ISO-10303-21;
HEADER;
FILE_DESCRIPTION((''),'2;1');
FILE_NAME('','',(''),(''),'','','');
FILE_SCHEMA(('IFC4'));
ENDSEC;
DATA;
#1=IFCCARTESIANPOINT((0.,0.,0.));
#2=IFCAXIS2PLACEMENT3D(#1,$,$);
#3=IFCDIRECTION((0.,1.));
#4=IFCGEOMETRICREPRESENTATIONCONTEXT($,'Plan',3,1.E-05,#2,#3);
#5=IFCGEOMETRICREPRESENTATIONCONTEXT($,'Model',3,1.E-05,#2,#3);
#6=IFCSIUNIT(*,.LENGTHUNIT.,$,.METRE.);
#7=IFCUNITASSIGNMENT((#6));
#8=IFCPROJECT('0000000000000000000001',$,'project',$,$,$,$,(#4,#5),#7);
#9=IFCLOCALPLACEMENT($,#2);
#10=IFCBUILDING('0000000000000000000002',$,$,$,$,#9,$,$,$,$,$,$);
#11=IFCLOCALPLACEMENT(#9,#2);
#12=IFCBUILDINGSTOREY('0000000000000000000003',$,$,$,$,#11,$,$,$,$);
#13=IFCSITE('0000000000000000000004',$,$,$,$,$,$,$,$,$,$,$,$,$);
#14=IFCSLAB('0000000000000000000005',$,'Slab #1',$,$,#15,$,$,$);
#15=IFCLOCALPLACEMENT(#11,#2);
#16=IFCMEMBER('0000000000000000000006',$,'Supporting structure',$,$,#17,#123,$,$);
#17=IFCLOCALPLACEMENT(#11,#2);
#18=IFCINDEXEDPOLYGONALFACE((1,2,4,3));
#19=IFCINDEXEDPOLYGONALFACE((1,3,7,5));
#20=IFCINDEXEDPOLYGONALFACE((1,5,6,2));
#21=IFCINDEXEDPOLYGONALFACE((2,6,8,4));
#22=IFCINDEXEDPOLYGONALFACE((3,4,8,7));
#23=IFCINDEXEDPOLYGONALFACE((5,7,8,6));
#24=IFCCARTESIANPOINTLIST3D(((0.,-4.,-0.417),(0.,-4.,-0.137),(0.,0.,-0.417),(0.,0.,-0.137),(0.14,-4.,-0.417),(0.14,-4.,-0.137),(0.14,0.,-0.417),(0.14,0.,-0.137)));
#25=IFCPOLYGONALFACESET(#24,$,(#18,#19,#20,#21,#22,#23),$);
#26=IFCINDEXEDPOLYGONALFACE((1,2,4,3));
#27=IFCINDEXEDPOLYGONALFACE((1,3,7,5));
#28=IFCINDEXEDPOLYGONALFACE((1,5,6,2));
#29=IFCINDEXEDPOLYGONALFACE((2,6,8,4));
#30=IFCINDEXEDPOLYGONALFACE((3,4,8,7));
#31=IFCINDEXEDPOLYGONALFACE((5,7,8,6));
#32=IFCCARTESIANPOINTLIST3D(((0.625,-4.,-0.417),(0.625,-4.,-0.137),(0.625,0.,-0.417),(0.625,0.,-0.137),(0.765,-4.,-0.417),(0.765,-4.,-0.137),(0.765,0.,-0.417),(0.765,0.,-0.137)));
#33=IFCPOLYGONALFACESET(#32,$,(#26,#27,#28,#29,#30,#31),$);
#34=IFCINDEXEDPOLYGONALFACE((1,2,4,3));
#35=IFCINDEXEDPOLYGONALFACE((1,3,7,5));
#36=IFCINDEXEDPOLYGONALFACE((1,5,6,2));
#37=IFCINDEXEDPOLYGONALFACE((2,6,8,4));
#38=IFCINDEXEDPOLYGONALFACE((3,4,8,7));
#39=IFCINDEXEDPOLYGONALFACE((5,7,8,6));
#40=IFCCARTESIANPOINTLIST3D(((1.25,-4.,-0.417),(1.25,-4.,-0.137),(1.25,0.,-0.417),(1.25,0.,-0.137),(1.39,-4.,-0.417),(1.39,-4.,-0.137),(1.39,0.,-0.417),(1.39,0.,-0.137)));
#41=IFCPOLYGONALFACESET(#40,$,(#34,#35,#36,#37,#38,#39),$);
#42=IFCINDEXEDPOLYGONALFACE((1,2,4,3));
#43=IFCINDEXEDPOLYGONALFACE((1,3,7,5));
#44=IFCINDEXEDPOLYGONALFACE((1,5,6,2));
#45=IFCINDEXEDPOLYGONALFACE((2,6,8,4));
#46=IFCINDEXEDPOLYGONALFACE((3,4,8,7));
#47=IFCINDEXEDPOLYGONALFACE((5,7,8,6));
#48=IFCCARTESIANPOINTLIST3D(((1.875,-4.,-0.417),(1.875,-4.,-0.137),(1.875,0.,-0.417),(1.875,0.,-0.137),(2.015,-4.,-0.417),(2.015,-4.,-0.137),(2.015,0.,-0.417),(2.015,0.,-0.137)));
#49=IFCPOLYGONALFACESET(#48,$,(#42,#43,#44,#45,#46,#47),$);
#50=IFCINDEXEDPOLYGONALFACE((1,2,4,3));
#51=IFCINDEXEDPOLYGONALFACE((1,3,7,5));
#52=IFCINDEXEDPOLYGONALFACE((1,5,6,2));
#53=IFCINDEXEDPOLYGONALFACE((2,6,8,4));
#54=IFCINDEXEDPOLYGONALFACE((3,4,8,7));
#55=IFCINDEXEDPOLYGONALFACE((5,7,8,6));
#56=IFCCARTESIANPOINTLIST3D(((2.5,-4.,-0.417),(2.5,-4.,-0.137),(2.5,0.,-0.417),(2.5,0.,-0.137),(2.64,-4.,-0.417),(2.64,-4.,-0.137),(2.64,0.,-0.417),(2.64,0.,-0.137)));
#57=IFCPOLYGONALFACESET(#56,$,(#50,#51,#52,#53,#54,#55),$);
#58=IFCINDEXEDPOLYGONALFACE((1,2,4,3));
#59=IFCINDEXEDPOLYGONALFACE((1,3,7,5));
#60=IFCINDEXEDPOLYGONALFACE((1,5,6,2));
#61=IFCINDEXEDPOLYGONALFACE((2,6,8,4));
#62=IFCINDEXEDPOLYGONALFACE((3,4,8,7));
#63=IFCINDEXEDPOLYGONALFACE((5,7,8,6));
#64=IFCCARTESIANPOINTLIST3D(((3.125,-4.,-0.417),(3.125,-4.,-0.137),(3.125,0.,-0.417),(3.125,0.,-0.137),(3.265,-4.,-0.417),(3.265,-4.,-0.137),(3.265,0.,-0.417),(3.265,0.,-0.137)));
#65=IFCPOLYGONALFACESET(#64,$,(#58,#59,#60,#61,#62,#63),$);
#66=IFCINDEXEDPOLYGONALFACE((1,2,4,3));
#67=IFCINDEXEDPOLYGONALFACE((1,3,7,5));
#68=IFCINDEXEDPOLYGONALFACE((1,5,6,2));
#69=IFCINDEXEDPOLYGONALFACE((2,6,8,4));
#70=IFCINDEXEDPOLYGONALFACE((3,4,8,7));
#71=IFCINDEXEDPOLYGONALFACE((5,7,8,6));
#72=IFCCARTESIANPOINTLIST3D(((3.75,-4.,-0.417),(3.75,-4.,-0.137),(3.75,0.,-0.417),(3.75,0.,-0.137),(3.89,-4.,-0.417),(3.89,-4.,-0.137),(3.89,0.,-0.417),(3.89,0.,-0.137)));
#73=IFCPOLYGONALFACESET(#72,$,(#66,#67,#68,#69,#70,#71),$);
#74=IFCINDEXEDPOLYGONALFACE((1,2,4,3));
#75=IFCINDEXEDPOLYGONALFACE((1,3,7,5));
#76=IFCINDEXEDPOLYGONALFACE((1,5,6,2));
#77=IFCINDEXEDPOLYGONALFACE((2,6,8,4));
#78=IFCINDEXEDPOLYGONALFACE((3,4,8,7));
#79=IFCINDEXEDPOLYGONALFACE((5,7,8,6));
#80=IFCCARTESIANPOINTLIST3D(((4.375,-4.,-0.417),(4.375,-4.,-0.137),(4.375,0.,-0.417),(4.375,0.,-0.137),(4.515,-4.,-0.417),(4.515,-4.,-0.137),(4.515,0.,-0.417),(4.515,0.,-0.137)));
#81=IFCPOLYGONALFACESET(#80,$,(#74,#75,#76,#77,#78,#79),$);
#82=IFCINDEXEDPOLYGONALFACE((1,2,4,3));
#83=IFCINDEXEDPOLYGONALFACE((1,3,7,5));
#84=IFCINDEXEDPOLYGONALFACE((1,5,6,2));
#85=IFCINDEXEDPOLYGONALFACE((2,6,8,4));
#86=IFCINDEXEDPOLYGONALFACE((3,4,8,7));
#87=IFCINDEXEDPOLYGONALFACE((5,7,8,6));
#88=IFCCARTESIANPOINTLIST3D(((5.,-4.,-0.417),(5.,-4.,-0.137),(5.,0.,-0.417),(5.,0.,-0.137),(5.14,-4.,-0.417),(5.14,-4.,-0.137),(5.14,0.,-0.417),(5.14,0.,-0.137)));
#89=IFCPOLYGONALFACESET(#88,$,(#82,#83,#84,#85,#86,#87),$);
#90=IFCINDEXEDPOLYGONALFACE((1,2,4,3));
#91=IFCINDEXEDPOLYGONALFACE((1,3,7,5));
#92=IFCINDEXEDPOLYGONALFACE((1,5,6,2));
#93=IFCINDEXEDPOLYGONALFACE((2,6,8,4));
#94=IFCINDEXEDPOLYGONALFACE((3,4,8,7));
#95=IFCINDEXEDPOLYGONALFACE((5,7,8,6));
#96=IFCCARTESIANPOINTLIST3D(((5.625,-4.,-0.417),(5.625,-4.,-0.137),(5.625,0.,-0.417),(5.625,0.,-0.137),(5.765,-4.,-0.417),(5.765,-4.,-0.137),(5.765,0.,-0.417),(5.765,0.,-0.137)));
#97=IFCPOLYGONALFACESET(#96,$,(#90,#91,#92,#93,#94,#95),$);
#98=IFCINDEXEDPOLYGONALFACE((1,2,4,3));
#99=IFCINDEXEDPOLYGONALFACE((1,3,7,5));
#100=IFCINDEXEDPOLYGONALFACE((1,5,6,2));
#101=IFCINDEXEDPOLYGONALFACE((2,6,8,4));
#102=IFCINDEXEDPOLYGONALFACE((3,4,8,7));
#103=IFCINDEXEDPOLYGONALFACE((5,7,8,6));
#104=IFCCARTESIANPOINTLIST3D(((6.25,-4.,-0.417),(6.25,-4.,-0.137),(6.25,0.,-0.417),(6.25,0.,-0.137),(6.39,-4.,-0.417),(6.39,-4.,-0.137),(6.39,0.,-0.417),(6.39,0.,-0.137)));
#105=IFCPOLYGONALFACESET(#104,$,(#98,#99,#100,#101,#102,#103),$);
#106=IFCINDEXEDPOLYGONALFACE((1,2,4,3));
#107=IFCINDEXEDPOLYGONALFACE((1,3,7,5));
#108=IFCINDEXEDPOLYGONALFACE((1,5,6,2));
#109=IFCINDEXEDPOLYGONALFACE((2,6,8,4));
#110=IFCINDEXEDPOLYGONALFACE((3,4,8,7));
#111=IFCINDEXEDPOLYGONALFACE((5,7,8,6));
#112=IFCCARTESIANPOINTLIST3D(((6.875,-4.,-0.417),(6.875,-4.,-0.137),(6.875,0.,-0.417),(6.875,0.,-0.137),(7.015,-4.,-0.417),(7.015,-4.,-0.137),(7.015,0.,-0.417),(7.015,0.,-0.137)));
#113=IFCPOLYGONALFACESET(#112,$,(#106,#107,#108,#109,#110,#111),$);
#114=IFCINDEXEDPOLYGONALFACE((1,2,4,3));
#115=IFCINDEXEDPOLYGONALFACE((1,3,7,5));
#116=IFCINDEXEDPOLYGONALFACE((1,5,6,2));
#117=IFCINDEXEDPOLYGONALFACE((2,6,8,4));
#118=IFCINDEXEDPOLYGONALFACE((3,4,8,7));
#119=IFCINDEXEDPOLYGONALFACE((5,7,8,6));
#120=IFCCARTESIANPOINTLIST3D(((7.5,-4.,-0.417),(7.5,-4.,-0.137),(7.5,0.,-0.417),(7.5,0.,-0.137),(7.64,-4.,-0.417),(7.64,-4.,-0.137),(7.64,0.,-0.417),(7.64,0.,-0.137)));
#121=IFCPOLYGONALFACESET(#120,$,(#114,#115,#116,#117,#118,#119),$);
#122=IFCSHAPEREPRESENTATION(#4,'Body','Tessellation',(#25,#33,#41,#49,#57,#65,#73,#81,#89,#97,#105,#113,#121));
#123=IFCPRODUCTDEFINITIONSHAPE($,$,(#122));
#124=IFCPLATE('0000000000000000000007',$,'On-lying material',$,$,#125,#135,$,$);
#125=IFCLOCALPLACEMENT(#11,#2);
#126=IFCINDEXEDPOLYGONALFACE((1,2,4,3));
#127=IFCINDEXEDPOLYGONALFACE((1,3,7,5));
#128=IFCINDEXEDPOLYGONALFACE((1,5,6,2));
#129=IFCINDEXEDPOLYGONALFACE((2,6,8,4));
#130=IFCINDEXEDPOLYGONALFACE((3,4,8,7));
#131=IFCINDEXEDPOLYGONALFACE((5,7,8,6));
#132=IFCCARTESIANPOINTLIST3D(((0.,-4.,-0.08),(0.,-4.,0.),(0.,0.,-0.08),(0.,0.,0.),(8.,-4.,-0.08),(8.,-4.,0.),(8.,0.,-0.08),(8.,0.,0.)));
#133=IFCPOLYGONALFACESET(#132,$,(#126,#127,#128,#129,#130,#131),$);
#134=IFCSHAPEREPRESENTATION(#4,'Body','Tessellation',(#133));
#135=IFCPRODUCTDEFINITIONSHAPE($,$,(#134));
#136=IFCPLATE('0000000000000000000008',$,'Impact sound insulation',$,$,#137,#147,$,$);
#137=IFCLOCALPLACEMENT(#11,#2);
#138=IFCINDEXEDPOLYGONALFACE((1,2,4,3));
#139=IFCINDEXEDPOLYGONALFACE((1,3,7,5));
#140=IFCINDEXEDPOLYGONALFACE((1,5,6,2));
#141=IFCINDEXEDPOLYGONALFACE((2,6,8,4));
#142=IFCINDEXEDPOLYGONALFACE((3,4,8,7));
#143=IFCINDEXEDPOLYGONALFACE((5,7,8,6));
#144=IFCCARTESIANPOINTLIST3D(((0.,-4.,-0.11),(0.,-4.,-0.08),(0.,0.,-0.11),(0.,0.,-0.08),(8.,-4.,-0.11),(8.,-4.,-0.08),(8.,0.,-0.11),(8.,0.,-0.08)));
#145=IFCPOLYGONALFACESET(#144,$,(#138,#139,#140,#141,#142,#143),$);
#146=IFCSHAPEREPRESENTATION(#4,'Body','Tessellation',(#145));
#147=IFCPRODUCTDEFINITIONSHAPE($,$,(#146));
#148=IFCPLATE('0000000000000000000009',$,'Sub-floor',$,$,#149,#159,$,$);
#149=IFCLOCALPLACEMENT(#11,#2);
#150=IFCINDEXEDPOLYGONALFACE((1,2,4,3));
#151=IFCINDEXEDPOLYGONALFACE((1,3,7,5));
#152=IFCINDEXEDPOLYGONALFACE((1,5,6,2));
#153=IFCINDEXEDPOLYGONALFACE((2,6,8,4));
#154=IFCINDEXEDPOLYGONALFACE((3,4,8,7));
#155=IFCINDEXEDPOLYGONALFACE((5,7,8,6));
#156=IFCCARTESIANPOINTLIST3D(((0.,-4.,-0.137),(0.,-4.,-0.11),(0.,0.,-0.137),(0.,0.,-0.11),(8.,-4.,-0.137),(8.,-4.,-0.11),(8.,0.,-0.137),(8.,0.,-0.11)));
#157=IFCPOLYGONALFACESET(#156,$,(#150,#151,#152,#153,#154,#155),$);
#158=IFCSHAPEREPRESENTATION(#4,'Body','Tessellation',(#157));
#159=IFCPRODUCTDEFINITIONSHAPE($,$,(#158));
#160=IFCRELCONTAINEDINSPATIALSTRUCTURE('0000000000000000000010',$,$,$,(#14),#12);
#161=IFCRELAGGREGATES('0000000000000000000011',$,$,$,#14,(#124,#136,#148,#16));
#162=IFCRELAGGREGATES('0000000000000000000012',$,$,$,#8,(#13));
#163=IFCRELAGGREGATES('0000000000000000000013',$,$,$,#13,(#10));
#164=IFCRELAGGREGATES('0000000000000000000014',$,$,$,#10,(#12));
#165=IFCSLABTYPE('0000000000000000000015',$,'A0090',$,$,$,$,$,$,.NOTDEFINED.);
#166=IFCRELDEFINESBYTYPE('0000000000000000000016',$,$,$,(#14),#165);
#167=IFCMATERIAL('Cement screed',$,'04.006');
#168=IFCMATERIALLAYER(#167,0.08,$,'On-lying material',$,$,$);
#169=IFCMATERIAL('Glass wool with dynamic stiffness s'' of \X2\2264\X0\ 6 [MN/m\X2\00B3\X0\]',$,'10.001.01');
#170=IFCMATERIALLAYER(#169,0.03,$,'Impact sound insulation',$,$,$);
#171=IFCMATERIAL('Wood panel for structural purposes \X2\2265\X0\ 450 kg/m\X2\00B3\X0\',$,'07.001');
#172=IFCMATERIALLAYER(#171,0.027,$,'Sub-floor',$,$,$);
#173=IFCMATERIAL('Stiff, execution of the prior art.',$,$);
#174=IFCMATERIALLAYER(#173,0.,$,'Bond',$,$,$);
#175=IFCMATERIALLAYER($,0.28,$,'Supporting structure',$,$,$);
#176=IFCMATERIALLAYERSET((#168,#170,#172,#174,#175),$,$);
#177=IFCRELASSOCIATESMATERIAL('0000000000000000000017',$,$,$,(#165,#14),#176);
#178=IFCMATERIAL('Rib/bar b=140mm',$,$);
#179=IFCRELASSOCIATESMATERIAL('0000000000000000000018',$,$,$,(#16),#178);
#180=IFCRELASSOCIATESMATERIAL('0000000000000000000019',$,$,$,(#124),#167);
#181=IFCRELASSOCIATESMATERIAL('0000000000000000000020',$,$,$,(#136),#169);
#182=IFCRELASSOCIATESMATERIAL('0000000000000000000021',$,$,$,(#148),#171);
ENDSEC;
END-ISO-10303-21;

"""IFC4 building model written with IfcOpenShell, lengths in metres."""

from ifc_helpers import new_model, si_unit, direction, frame, frame_2d, origin, origin_with_axes, place, context, project, spatial, rectangle, extrude, material, layer, layer_set, type_object, element, aggregate, save


model = new_model("IFC4")

# Units and contexts
plan_context = context("Plan", 3, precision=1e-05, world=origin(), true_north=direction((0.0, 1.0)))
model_context = context("Model", 3, precision=1e-05, world=origin(), true_north=direction((0.0, 1.0)))
ifc_project = project(units=[si_unit("LENGTHUNIT", "METRE")], contexts=[plan_context, model_context])

# Site, building, storey
site = spatial("IfcSite", under=ifc_project)
building_placement = place(None, origin())
building = spatial("IfcBuilding", under=site, at=building_placement)
storey_placement = place(building_placement, origin())
storey = spatial("IfcBuildingStorey", under=building, at=storey_placement)

# Slab, member, plates
ifc_material_1 = material(Name="Cement screed", Category="04.006")
ifc_layer_1 = layer(ifc_material_1, 0.08, Name="On-lying material")
ifc_material_2 = material(Name="Glass wool with dynamic stiffness s' of ≤ 6 [MN/m³]", Category="10.001.01")
ifc_layer_2 = layer(ifc_material_2, 0.03, Name="Impact sound insulation")
ifc_material_3 = material(Name="Wood panel for structural purposes ≥ 450 kg/m³", Category="07.001")
ifc_layer_3 = layer(ifc_material_3, 0.027, Name="Sub-floor")
ifc_material_4 = material(Name="Stiff, execution of the prior art.")
ifc_layer_4 = layer(ifc_material_4, 0.0, Name="Bond")
ifc_layer_5 = layer(None, 0.28, Name="Supporting structure")
ifc_layer_set = layer_set([ifc_layer_1, ifc_layer_2, ifc_layer_3, ifc_layer_4, ifc_layer_5])
slab_type = type_object("IfcSlabType", Name="A0090", PredefinedType="NOTDEFINED", material=ifc_layer_set)
slab_placement = place(None, frame((0.0, 0.0, 0.0), z_axis=(0.0, 0.0, -1.0), x_axis=(1.0, 0.0, 0.0)))
slab = element("IfcSlab", 1, at=slab_placement, inside=storey, type_object=slab_type, material=ifc_layer_set, Name="Slab #1")
ifc_material_5 = material(Name="Rib/bar b=140mm")
member_placement = place(slab_placement, origin())
member = element("IfcMember", 2, at=member_placement, material=ifc_material_5, Name="Supporting structure", context=plan_context, shape_type="SweptSolid", body=[
    extrude(rectangle(XDim=0.14, YDim=0.28, at=frame_2d((0.07, 0.14), x_axis=(1.0, 0.0))), frame((0.0, 4.0, 0.137), z_axis=(0.0, -1.0, 0.0), x_axis=(1.0, 0.0, 0.0)), (0.0, 0.0, 1.0), 4.0),
    extrude(rectangle(XDim=0.14, YDim=0.28, at=frame_2d((0.07, 0.14), x_axis=(1.0, 0.0))), frame((0.625, 4.0, 0.137), z_axis=(0.0, -1.0, 0.0), x_axis=(1.0, 0.0, 0.0)), (0.0, 0.0, 1.0), 4.0),
    extrude(rectangle(XDim=0.14, YDim=0.28, at=frame_2d((0.07, 0.14), x_axis=(1.0, 0.0))), frame((1.25, 4.0, 0.137), z_axis=(0.0, -1.0, 0.0), x_axis=(1.0, 0.0, 0.0)), (0.0, 0.0, 1.0), 4.0),
    extrude(rectangle(XDim=0.14, YDim=0.28, at=frame_2d((0.07, 0.14), x_axis=(1.0, 0.0))), frame((1.875, 4.0, 0.137), z_axis=(0.0, -1.0, 0.0), x_axis=(1.0, 0.0, 0.0)), (0.0, 0.0, 1.0), 4.0),
    extrude(rectangle(XDim=0.14, YDim=0.28, at=frame_2d((0.07, 0.14), x_axis=(1.0, 0.0))), frame((2.5, 4.0, 0.137), z_axis=(0.0, -1.0, 0.0), x_axis=(1.0, 0.0, 0.0)), (0.0, 0.0, 1.0), 4.0),
    extrude(rectangle(XDim=0.14, YDim=0.28, at=frame_2d((0.07, 0.14), x_axis=(1.0, 0.0))), frame((3.125, 4.0, 0.137), z_axis=(0.0, -1.0, 0.0), x_axis=(1.0, 0.0, 0.0)), (0.0, 0.0, 1.0), 4.0),
    extrude(rectangle(XDim=0.14, YDim=0.28, at=frame_2d((0.07, 0.14), x_axis=(1.0, 0.0))), frame((3.75, 4.0, 0.137), z_axis=(0.0, -1.0, 0.0), x_axis=(1.0, 0.0, 0.0)), (0.0, 0.0, 1.0), 4.0),
    extrude(rectangle(XDim=0.14, YDim=0.28, at=frame_2d((0.07, 0.14), x_axis=(1.0, 0.0))), frame((4.375, 4.0, 0.137), z_axis=(0.0, -1.0, 0.0), x_axis=(1.0, 0.0, 0.0)), (0.0, 0.0, 1.0), 4.0),
    extrude(rectangle(XDim=0.14, YDim=0.28, at=frame_2d((0.07, 0.14), x_axis=(1.0, 0.0))), frame((5.0, 4.0, 0.137), z_axis=(0.0, -1.0, 0.0), x_axis=(1.0, 0.0, 0.0)), (0.0, 0.0, 1.0), 4.0),
    extrude(rectangle(XDim=0.14, YDim=0.28, at=frame_2d((0.07, 0.14), x_axis=(1.0, 0.0))), frame((5.625, 4.0, 0.137), z_axis=(0.0, -1.0, 0.0), x_axis=(1.0, 0.0, 0.0)), (0.0, 0.0, 1.0), 4.0),
    extrude(rectangle(XDim=0.14, YDim=0.28, at=frame_2d((0.07, 0.14), x_axis=(1.0, 0.0))), frame((6.25, 4.0, 0.137), z_axis=(0.0, -1.0, 0.0), x_axis=(1.0, 0.0, 0.0)), (0.0, 0.0, 1.0), 4.0),
    extrude(rectangle(XDim=0.14, YDim=0.28, at=frame_2d((0.07, 0.14), x_axis=(1.0, 0.0))), frame((6.875, 4.0, 0.137), z_axis=(0.0, -1.0, 0.0), x_axis=(1.0, 0.0, 0.0)), (0.0, 0.0, 1.0), 4.0),
    extrude(rectangle(XDim=0.14, YDim=0.28, at=frame_2d((0.07, 0.14), x_axis=(1.0, 0.0))), frame((7.5, 4.0, 0.137), z_axis=(0.0, -1.0, 0.0), x_axis=(1.0, 0.0, 0.0)), (0.0, 0.0, 1.0), 4.0),
])
plate_1_placement = place(slab_placement, origin())
plate_1 = element("IfcPlate", 3, at=plate_1_placement, material=ifc_material_1, Name="On-lying material", context=plan_context, shape_type="SweptSolid", body=[
    extrude(rectangle(XDim=8.0, YDim=4.0, at=frame_2d((4.0, 2.0), x_axis=(1.0, 0.0))), origin_with_axes(), (0.0, 0.0, 1.0), 0.08),
])
plate_2_placement = place(slab_placement, origin())
plate_2 = element("IfcPlate", 4, at=plate_2_placement, material=ifc_material_2, Name="Impact sound insulation", context=plan_context, shape_type="SweptSolid", body=[
    extrude(rectangle(XDim=8.0, YDim=4.0, at=frame_2d((4.0, 2.0), x_axis=(1.0, 0.0))), frame((0.0, 0.0, 0.08), z_axis=(0.0, 0.0, 1.0), x_axis=(1.0, 0.0, 0.0)), (0.0, 0.0, 1.0), 0.03),
])
plate_3_placement = place(slab_placement, origin())
plate_3 = element("IfcPlate", 5, at=plate_3_placement, material=ifc_material_3, Name="Sub-floor", context=plan_context, shape_type="SweptSolid", body=[
    extrude(rectangle(XDim=8.0, YDim=4.0, at=frame_2d((4.0, 2.0), x_axis=(1.0, 0.0))), frame((0.0, 0.0, 0.11), z_axis=(0.0, 0.0, 1.0), x_axis=(1.0, 0.0, 0.0)), (0.0, 0.0, 1.0), 0.027),
])
aggregate(slab, [plate_1, plate_2, plate_3, member])

save(model, "model.ifc")
